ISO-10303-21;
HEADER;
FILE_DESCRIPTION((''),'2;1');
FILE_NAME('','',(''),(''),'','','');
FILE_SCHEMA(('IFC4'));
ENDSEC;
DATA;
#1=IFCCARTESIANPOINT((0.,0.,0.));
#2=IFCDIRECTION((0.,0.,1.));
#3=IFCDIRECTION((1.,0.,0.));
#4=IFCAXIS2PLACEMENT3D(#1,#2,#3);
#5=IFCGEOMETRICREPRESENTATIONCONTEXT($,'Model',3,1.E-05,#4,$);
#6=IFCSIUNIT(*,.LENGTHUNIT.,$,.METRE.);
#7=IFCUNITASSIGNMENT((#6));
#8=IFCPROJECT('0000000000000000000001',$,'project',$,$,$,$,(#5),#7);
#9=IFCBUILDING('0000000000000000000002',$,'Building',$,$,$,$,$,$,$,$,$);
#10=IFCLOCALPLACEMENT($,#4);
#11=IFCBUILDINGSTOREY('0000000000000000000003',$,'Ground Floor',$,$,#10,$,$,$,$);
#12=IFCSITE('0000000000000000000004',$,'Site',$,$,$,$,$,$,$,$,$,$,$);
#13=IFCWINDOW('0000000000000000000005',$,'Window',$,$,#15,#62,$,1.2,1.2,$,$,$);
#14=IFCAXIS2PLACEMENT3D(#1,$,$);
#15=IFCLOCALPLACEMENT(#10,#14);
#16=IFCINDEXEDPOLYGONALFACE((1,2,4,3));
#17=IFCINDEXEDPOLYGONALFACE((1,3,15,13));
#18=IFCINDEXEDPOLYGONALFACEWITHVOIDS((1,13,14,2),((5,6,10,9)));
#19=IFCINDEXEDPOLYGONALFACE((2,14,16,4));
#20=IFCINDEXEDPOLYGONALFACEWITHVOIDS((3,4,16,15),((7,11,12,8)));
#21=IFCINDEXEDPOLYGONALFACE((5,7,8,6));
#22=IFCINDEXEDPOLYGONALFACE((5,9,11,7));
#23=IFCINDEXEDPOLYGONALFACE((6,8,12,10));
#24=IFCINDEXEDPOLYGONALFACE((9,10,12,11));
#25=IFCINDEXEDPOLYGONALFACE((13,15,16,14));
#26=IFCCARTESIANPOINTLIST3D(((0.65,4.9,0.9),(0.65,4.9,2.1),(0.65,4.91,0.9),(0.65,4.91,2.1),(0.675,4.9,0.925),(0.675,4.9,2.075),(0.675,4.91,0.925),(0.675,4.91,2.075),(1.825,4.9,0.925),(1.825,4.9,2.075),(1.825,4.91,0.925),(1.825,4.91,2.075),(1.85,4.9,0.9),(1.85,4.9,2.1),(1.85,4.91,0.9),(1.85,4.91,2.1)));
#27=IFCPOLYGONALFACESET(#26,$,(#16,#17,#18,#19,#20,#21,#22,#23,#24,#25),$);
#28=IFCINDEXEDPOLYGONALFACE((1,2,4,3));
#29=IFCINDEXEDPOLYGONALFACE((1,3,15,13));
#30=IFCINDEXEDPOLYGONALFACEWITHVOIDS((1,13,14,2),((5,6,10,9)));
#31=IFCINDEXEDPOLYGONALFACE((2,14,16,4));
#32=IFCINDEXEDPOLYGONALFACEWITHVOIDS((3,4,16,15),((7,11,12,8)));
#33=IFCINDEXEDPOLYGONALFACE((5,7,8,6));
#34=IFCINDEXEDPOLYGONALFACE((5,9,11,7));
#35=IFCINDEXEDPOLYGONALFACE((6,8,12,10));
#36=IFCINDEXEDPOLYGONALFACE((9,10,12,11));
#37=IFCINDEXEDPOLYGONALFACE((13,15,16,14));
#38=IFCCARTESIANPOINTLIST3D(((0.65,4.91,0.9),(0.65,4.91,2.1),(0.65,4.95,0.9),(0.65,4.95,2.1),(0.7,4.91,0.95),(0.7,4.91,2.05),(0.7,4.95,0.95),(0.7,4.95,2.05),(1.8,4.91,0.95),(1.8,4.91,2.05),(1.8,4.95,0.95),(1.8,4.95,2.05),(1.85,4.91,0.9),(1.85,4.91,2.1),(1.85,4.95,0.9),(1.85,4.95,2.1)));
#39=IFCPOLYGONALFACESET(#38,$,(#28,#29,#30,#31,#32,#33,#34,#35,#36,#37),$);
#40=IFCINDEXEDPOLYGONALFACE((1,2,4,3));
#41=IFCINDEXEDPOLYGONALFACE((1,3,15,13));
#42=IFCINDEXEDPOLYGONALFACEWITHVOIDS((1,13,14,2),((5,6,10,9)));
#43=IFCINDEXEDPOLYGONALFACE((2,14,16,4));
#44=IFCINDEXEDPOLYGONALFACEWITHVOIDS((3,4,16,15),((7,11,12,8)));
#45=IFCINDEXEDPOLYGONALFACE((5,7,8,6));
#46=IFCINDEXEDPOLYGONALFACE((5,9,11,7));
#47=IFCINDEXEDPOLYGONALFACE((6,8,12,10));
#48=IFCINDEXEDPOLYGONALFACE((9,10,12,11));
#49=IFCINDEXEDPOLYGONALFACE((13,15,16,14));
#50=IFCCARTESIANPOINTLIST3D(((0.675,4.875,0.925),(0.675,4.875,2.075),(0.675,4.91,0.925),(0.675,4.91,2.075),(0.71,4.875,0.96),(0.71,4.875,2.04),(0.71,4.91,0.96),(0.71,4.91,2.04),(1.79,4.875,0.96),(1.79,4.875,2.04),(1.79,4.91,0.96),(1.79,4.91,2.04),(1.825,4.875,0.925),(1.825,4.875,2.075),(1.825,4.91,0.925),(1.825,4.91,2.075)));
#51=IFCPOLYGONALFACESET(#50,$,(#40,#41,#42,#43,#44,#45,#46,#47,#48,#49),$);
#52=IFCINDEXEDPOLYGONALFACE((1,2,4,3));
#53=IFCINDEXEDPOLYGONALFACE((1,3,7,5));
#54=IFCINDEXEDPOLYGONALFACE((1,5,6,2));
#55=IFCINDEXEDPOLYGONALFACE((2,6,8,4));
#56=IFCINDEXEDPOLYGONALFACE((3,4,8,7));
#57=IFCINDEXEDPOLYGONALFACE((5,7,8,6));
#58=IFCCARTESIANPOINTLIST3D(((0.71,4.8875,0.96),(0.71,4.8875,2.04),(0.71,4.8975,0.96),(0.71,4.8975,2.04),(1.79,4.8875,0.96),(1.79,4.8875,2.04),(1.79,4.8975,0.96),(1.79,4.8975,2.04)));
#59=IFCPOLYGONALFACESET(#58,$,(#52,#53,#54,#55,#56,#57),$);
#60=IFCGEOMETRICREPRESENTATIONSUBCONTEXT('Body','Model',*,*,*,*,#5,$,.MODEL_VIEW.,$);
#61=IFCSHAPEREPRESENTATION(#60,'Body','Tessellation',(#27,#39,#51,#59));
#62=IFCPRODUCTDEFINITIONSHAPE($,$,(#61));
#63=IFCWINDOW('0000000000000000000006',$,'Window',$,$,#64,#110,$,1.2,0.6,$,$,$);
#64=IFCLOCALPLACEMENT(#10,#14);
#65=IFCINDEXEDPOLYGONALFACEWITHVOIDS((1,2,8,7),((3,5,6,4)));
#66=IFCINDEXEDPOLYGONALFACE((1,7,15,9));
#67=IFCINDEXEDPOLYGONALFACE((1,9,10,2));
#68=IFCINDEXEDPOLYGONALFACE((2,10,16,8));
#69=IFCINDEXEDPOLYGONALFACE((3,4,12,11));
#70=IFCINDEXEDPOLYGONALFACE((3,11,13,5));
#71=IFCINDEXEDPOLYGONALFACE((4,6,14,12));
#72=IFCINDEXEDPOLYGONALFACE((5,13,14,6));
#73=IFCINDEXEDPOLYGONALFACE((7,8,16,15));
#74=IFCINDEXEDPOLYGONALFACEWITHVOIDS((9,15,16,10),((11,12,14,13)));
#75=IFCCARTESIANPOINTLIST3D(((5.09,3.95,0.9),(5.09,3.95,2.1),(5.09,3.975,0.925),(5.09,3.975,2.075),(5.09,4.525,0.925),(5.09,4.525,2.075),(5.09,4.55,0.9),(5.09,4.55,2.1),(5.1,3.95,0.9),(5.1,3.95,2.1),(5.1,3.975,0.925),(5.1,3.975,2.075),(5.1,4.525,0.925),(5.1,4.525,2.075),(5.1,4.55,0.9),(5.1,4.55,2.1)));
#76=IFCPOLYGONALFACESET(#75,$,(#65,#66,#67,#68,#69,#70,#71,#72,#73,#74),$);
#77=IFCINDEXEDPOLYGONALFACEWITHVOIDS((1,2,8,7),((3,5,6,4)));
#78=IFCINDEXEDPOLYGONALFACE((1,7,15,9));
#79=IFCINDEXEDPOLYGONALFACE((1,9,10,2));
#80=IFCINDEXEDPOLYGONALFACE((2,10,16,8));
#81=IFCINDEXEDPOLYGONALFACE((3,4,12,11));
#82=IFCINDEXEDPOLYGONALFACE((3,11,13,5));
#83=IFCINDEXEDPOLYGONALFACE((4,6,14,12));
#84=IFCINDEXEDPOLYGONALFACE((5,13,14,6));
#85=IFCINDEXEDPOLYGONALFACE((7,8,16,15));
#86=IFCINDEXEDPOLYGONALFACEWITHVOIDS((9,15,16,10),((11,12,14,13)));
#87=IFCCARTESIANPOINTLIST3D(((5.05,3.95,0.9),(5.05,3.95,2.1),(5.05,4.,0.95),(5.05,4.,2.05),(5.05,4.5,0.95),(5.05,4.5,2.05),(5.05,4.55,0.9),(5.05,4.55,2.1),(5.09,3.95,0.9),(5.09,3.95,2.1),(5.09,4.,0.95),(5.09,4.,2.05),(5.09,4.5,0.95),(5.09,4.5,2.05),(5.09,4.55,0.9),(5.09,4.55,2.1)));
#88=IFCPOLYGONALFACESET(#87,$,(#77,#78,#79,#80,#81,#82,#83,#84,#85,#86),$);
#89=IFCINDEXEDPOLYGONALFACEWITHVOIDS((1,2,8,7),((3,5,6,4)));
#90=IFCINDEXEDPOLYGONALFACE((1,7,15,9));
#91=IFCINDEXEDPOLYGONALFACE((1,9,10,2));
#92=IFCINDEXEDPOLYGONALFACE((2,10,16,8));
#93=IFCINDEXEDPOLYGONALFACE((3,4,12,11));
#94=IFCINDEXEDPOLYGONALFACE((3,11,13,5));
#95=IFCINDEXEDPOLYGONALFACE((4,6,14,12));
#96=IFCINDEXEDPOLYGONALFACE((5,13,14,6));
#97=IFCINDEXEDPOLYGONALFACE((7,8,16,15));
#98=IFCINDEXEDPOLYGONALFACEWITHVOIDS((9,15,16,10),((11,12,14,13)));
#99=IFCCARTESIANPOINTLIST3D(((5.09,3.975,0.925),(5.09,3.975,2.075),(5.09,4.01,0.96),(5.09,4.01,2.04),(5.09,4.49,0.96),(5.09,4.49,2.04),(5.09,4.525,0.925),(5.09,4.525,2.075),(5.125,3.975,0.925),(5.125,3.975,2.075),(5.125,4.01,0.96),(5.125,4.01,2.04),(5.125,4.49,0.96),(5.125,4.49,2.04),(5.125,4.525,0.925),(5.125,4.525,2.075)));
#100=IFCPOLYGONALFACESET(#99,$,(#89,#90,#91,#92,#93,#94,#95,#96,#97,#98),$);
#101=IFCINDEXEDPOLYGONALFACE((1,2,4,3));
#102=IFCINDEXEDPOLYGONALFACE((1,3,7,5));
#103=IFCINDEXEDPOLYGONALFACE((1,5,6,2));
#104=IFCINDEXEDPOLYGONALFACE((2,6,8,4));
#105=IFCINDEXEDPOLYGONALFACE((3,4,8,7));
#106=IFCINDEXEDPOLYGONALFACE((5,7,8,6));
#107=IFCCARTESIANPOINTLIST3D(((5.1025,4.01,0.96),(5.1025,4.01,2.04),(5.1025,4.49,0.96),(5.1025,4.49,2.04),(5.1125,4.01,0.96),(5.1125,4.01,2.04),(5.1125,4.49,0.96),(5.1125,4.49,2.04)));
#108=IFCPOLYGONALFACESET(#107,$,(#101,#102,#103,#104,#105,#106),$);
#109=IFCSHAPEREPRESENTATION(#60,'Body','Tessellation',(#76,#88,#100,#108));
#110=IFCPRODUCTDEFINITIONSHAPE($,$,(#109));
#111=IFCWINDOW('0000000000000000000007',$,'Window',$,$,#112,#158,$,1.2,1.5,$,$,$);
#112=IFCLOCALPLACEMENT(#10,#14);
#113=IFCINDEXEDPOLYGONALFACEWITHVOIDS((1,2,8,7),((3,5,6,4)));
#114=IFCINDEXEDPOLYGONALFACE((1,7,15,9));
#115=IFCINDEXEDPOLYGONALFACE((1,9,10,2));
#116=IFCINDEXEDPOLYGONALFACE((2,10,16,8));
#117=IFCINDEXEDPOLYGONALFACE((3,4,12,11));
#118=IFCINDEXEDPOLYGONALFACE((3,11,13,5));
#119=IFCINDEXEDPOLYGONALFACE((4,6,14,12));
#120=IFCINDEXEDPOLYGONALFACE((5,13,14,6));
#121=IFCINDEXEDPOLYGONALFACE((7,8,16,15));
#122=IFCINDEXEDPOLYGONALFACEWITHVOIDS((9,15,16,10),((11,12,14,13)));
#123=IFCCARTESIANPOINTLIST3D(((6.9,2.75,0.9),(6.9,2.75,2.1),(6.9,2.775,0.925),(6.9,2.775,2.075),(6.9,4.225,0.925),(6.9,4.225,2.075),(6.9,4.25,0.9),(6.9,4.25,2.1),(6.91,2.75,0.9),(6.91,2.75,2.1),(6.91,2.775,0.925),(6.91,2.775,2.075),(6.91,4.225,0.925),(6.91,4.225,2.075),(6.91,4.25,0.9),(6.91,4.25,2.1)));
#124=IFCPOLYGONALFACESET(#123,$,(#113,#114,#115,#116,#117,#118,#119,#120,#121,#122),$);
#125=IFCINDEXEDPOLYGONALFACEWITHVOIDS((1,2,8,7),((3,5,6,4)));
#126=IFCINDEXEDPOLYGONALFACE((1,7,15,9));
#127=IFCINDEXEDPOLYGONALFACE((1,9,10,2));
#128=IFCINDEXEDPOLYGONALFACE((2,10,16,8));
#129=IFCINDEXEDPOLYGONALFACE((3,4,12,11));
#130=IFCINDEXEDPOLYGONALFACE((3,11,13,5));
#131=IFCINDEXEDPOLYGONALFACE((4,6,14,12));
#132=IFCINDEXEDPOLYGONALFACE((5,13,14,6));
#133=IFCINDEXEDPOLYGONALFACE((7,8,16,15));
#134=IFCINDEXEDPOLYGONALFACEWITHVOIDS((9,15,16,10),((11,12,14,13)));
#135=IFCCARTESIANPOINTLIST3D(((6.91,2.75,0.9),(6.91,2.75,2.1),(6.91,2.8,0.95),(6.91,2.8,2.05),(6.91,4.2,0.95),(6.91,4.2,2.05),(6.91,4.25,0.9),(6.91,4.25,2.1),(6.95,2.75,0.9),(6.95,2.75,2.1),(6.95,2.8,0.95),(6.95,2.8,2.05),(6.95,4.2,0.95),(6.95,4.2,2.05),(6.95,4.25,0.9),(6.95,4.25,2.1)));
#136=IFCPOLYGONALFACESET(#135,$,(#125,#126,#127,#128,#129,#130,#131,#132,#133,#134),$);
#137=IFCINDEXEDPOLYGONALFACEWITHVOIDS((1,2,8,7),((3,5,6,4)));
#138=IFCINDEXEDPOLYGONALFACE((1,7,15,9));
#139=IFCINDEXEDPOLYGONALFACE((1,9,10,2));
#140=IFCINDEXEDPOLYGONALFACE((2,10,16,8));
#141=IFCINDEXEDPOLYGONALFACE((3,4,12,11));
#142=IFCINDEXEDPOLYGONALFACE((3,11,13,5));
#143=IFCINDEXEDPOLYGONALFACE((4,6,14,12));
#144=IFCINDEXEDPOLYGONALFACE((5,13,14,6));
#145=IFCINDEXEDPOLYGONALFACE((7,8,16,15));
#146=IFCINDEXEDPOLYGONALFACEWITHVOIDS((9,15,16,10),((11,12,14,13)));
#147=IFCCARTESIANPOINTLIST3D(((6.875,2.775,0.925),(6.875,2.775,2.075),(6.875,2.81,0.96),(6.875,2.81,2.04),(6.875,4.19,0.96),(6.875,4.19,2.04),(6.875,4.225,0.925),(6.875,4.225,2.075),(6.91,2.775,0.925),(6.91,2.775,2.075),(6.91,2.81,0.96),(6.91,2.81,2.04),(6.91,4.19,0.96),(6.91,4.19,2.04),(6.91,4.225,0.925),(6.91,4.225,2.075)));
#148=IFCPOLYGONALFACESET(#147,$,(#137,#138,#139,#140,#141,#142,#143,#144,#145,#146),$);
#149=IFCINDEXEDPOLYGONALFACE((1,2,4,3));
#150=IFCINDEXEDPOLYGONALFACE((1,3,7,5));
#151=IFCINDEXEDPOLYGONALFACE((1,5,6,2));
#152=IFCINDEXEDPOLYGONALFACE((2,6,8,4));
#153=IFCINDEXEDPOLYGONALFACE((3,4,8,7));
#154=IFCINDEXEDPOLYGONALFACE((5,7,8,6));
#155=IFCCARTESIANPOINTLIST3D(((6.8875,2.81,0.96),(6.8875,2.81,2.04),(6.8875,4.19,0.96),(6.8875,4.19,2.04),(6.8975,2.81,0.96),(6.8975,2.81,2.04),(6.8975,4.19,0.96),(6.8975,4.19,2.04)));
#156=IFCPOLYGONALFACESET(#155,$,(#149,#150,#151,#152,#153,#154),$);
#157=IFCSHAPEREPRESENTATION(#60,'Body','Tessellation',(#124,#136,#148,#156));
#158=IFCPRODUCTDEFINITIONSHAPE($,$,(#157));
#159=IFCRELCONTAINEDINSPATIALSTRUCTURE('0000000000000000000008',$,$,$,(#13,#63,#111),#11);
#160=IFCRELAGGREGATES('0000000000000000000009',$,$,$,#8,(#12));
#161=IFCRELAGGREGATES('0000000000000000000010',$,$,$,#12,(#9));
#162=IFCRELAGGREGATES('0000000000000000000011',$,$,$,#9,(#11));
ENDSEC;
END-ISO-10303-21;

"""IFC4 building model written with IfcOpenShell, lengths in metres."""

from ifc_helpers import new_model, si_unit, frame, origin_with_axes, place, context, subcontext, project, spatial, line, indexed_curve, outline, extrude, element, save


model = new_model("IFC4")

# Units and contexts
model_context = context("Model", 3, precision=1e-05, world=origin_with_axes())
body_context = subcontext(model_context, "Body", "Model", "MODEL_VIEW")
ifc_project = project(units=[si_unit("LENGTHUNIT", "METRE")], contexts=[model_context])

# Site, building, storey
site = spatial("IfcSite", under=ifc_project, Name="Site")
building = spatial("IfcBuilding", under=site, Name="Building")
storey_placement = place(None, origin_with_axes())
storey = spatial("IfcBuildingStorey", under=building, at=storey_placement, Name="Ground Floor")

# Windows
for number, where, z_axis, x_axis, name in (
    (1, (1.85, 5.0, 0.9), (0.0, 0.0, 1.0), (-1.0, 0.0, 0.0), "Window"),
):
    element("IfcWindow", number, at=place(storey_placement, frame(where, z_axis=z_axis, x_axis=x_axis)), inside=storey, Name=name, OverallHeight=1.2, OverallWidth=1.2, context=body_context, shape_type="SweptSolid", body=[
        extrude(outline(indexed_curve([(0.0, 0.0), (1.2, 0.0), (1.2, 1.2), (0.0, 1.2)], segments=[line(1, 2, 3, 4, 1)]), holes=[indexed_curve([(0.025, 0.025), (1.175, 0.025), (1.175, 1.175), (0.025, 1.175)], segments=[line(1, 2, 3, 4, 1)])]), frame((0.0, 0.09, 0.0), z_axis=(0.0, -1.0, 0.0), x_axis=(1.0, 0.0, 0.0)), (0.0, 0.0, -1.0), 0.01),
        extrude(outline(indexed_curve([(0.0, 0.0), (1.2, 0.0), (1.2, 1.2), (0.0, 1.2)], segments=[line(1, 2, 3, 4, 1)]), holes=[indexed_curve([(0.05, 0.05), (1.15, 0.05), (1.15, 1.15), (0.05, 1.15)], segments=[line(1, 2, 3, 4, 1)])]), frame((0.0, 0.05, 0.0), z_axis=(0.0, -1.0, 0.0), x_axis=(1.0, 0.0, 0.0)), (0.0, 0.0, -1.0), 0.04),
        extrude(outline(indexed_curve([(0.0, 0.0), (1.15, 0.0), (1.15, 1.15), (0.0, 1.15)], segments=[line(1, 2, 3, 4, 1)]), holes=[indexed_curve([(0.035, 0.035), (1.115, 0.035), (1.115, 1.115), (0.035, 1.115)], segments=[line(1, 2, 3, 4, 1)])]), frame((0.025, 0.09, 0.025), z_axis=(0.0, -1.0, 0.0), x_axis=(1.0, 0.0, 0.0)), (0.0, 0.0, -1.0), 0.035),
        extrude(outline(indexed_curve([(0.035, 0.035), (1.115, 0.035), (1.115, 1.115), (0.035, 1.115)], segments=[line(1, 2, 3, 4, 1)])), frame((0.025, 0.1025, 0.025), z_axis=(0.0, -1.0, 0.0), x_axis=(1.0, 0.0, 0.0)), (0.0, 0.0, -1.0), 0.01),
    ])
window_1_placement = place(storey_placement, frame((5.0, 4.55, 0.9), z_axis=(0.0, 0.0, 1.0), x_axis=(0.0, -1.0, 0.0)))
element("IfcWindow", 2, at=window_1_placement, inside=storey, Name="Window", OverallHeight=1.2, OverallWidth=0.6, context=body_context, shape_type="SweptSolid", body=[
    extrude(outline(indexed_curve([(0.0, 0.0), (0.6, 0.0), (0.6, 1.2), (0.0, 1.2)], segments=[line(1, 2, 3, 4, 1)]), holes=[indexed_curve([(0.025, 0.025), (0.575, 0.025), (0.575, 1.175), (0.025, 1.175)], segments=[line(1, 2, 3, 4, 1)])]), frame((0.0, 0.09, 0.0), z_axis=(0.0, -1.0, 0.0), x_axis=(1.0, 0.0, 0.0)), (0.0, 0.0, -1.0), 0.01),
    extrude(outline(indexed_curve([(0.0, 0.0), (0.6, 0.0), (0.6, 1.2), (0.0, 1.2)], segments=[line(1, 2, 3, 4, 1)]), holes=[indexed_curve([(0.05, 0.05), (0.55, 0.05), (0.55, 1.15), (0.05, 1.15)], segments=[line(1, 2, 3, 4, 1)])]), frame((0.0, 0.05, 0.0), z_axis=(0.0, -1.0, 0.0), x_axis=(1.0, 0.0, 0.0)), (0.0, 0.0, -1.0), 0.04),
    extrude(outline(indexed_curve([(0.0, 0.0), (0.55, 0.0), (0.55, 1.15), (0.0, 1.15)], segments=[line(1, 2, 3, 4, 1)]), holes=[indexed_curve([(0.035, 0.035), (0.515, 0.035), (0.515, 1.115), (0.035, 1.115)], segments=[line(1, 2, 3, 4, 1)])]), frame((0.025, 0.09, 0.025), z_axis=(0.0, -1.0, 0.0), x_axis=(1.0, 0.0, 0.0)), (0.0, 0.0, -1.0), 0.035),
    extrude(outline(indexed_curve([(0.035, 0.035), (0.515, 0.035), (0.515, 1.115), (0.035, 1.115)], segments=[line(1, 2, 3, 4, 1)])), frame((0.025, 0.1025, 0.025), z_axis=(0.0, -1.0, 0.0), x_axis=(1.0, 0.0, 0.0)), (0.0, 0.0, -1.0), 0.01),
])
window_2_placement = place(storey_placement, frame((7.0, 2.75, 0.9), z_axis=(0.0, 0.0, 1.0), x_axis=(0.0, 1.0, 0.0)))
element("IfcWindow", 3, at=window_2_placement, inside=storey, Name="Window", OverallHeight=1.2, OverallWidth=1.5, context=body_context, shape_type="SweptSolid", body=[
    extrude(outline(indexed_curve([(0.0, 0.0), (1.5, 0.0), (1.5, 1.2), (0.0, 1.2)], segments=[line(1, 2, 3, 4, 1)]), holes=[indexed_curve([(0.025, 0.025), (1.475, 0.025), (1.475, 1.175), (0.025, 1.175)], segments=[line(1, 2, 3, 4, 1)])]), frame((0.0, 0.09, 0.0), z_axis=(0.0, -1.0, 0.0), x_axis=(1.0, 0.0, 0.0)), (0.0, 0.0, -1.0), 0.01),
    extrude(outline(indexed_curve([(0.0, 0.0), (1.5, 0.0), (1.5, 1.2), (0.0, 1.2)], segments=[line(1, 2, 3, 4, 1)]), holes=[indexed_curve([(0.05, 0.05), (1.45, 0.05), (1.45, 1.15), (0.05, 1.15)], segments=[line(1, 2, 3, 4, 1)])]), frame((0.0, 0.05, 0.0), z_axis=(0.0, -1.0, 0.0), x_axis=(1.0, 0.0, 0.0)), (0.0, 0.0, -1.0), 0.04),
    extrude(outline(indexed_curve([(0.0, 0.0), (1.45, 0.0), (1.45, 1.15), (0.0, 1.15)], segments=[line(1, 2, 3, 4, 1)]), holes=[indexed_curve([(0.035, 0.035), (1.415, 0.035), (1.415, 1.115), (0.035, 1.115)], segments=[line(1, 2, 3, 4, 1)])]), frame((0.025, 0.09, 0.025), z_axis=(0.0, -1.0, 0.0), x_axis=(1.0, 0.0, 0.0)), (0.0, 0.0, -1.0), 0.035),
    extrude(outline(indexed_curve([(0.035, 0.035), (1.415, 0.035), (1.415, 1.115), (0.035, 1.115)], segments=[line(1, 2, 3, 4, 1)])), frame((0.025, 0.1025, 0.025), z_axis=(0.0, -1.0, 0.0), x_axis=(1.0, 0.0, 0.0)), (0.0, 0.0, -1.0), 0.01),
])

save(model, "model.ifc")
